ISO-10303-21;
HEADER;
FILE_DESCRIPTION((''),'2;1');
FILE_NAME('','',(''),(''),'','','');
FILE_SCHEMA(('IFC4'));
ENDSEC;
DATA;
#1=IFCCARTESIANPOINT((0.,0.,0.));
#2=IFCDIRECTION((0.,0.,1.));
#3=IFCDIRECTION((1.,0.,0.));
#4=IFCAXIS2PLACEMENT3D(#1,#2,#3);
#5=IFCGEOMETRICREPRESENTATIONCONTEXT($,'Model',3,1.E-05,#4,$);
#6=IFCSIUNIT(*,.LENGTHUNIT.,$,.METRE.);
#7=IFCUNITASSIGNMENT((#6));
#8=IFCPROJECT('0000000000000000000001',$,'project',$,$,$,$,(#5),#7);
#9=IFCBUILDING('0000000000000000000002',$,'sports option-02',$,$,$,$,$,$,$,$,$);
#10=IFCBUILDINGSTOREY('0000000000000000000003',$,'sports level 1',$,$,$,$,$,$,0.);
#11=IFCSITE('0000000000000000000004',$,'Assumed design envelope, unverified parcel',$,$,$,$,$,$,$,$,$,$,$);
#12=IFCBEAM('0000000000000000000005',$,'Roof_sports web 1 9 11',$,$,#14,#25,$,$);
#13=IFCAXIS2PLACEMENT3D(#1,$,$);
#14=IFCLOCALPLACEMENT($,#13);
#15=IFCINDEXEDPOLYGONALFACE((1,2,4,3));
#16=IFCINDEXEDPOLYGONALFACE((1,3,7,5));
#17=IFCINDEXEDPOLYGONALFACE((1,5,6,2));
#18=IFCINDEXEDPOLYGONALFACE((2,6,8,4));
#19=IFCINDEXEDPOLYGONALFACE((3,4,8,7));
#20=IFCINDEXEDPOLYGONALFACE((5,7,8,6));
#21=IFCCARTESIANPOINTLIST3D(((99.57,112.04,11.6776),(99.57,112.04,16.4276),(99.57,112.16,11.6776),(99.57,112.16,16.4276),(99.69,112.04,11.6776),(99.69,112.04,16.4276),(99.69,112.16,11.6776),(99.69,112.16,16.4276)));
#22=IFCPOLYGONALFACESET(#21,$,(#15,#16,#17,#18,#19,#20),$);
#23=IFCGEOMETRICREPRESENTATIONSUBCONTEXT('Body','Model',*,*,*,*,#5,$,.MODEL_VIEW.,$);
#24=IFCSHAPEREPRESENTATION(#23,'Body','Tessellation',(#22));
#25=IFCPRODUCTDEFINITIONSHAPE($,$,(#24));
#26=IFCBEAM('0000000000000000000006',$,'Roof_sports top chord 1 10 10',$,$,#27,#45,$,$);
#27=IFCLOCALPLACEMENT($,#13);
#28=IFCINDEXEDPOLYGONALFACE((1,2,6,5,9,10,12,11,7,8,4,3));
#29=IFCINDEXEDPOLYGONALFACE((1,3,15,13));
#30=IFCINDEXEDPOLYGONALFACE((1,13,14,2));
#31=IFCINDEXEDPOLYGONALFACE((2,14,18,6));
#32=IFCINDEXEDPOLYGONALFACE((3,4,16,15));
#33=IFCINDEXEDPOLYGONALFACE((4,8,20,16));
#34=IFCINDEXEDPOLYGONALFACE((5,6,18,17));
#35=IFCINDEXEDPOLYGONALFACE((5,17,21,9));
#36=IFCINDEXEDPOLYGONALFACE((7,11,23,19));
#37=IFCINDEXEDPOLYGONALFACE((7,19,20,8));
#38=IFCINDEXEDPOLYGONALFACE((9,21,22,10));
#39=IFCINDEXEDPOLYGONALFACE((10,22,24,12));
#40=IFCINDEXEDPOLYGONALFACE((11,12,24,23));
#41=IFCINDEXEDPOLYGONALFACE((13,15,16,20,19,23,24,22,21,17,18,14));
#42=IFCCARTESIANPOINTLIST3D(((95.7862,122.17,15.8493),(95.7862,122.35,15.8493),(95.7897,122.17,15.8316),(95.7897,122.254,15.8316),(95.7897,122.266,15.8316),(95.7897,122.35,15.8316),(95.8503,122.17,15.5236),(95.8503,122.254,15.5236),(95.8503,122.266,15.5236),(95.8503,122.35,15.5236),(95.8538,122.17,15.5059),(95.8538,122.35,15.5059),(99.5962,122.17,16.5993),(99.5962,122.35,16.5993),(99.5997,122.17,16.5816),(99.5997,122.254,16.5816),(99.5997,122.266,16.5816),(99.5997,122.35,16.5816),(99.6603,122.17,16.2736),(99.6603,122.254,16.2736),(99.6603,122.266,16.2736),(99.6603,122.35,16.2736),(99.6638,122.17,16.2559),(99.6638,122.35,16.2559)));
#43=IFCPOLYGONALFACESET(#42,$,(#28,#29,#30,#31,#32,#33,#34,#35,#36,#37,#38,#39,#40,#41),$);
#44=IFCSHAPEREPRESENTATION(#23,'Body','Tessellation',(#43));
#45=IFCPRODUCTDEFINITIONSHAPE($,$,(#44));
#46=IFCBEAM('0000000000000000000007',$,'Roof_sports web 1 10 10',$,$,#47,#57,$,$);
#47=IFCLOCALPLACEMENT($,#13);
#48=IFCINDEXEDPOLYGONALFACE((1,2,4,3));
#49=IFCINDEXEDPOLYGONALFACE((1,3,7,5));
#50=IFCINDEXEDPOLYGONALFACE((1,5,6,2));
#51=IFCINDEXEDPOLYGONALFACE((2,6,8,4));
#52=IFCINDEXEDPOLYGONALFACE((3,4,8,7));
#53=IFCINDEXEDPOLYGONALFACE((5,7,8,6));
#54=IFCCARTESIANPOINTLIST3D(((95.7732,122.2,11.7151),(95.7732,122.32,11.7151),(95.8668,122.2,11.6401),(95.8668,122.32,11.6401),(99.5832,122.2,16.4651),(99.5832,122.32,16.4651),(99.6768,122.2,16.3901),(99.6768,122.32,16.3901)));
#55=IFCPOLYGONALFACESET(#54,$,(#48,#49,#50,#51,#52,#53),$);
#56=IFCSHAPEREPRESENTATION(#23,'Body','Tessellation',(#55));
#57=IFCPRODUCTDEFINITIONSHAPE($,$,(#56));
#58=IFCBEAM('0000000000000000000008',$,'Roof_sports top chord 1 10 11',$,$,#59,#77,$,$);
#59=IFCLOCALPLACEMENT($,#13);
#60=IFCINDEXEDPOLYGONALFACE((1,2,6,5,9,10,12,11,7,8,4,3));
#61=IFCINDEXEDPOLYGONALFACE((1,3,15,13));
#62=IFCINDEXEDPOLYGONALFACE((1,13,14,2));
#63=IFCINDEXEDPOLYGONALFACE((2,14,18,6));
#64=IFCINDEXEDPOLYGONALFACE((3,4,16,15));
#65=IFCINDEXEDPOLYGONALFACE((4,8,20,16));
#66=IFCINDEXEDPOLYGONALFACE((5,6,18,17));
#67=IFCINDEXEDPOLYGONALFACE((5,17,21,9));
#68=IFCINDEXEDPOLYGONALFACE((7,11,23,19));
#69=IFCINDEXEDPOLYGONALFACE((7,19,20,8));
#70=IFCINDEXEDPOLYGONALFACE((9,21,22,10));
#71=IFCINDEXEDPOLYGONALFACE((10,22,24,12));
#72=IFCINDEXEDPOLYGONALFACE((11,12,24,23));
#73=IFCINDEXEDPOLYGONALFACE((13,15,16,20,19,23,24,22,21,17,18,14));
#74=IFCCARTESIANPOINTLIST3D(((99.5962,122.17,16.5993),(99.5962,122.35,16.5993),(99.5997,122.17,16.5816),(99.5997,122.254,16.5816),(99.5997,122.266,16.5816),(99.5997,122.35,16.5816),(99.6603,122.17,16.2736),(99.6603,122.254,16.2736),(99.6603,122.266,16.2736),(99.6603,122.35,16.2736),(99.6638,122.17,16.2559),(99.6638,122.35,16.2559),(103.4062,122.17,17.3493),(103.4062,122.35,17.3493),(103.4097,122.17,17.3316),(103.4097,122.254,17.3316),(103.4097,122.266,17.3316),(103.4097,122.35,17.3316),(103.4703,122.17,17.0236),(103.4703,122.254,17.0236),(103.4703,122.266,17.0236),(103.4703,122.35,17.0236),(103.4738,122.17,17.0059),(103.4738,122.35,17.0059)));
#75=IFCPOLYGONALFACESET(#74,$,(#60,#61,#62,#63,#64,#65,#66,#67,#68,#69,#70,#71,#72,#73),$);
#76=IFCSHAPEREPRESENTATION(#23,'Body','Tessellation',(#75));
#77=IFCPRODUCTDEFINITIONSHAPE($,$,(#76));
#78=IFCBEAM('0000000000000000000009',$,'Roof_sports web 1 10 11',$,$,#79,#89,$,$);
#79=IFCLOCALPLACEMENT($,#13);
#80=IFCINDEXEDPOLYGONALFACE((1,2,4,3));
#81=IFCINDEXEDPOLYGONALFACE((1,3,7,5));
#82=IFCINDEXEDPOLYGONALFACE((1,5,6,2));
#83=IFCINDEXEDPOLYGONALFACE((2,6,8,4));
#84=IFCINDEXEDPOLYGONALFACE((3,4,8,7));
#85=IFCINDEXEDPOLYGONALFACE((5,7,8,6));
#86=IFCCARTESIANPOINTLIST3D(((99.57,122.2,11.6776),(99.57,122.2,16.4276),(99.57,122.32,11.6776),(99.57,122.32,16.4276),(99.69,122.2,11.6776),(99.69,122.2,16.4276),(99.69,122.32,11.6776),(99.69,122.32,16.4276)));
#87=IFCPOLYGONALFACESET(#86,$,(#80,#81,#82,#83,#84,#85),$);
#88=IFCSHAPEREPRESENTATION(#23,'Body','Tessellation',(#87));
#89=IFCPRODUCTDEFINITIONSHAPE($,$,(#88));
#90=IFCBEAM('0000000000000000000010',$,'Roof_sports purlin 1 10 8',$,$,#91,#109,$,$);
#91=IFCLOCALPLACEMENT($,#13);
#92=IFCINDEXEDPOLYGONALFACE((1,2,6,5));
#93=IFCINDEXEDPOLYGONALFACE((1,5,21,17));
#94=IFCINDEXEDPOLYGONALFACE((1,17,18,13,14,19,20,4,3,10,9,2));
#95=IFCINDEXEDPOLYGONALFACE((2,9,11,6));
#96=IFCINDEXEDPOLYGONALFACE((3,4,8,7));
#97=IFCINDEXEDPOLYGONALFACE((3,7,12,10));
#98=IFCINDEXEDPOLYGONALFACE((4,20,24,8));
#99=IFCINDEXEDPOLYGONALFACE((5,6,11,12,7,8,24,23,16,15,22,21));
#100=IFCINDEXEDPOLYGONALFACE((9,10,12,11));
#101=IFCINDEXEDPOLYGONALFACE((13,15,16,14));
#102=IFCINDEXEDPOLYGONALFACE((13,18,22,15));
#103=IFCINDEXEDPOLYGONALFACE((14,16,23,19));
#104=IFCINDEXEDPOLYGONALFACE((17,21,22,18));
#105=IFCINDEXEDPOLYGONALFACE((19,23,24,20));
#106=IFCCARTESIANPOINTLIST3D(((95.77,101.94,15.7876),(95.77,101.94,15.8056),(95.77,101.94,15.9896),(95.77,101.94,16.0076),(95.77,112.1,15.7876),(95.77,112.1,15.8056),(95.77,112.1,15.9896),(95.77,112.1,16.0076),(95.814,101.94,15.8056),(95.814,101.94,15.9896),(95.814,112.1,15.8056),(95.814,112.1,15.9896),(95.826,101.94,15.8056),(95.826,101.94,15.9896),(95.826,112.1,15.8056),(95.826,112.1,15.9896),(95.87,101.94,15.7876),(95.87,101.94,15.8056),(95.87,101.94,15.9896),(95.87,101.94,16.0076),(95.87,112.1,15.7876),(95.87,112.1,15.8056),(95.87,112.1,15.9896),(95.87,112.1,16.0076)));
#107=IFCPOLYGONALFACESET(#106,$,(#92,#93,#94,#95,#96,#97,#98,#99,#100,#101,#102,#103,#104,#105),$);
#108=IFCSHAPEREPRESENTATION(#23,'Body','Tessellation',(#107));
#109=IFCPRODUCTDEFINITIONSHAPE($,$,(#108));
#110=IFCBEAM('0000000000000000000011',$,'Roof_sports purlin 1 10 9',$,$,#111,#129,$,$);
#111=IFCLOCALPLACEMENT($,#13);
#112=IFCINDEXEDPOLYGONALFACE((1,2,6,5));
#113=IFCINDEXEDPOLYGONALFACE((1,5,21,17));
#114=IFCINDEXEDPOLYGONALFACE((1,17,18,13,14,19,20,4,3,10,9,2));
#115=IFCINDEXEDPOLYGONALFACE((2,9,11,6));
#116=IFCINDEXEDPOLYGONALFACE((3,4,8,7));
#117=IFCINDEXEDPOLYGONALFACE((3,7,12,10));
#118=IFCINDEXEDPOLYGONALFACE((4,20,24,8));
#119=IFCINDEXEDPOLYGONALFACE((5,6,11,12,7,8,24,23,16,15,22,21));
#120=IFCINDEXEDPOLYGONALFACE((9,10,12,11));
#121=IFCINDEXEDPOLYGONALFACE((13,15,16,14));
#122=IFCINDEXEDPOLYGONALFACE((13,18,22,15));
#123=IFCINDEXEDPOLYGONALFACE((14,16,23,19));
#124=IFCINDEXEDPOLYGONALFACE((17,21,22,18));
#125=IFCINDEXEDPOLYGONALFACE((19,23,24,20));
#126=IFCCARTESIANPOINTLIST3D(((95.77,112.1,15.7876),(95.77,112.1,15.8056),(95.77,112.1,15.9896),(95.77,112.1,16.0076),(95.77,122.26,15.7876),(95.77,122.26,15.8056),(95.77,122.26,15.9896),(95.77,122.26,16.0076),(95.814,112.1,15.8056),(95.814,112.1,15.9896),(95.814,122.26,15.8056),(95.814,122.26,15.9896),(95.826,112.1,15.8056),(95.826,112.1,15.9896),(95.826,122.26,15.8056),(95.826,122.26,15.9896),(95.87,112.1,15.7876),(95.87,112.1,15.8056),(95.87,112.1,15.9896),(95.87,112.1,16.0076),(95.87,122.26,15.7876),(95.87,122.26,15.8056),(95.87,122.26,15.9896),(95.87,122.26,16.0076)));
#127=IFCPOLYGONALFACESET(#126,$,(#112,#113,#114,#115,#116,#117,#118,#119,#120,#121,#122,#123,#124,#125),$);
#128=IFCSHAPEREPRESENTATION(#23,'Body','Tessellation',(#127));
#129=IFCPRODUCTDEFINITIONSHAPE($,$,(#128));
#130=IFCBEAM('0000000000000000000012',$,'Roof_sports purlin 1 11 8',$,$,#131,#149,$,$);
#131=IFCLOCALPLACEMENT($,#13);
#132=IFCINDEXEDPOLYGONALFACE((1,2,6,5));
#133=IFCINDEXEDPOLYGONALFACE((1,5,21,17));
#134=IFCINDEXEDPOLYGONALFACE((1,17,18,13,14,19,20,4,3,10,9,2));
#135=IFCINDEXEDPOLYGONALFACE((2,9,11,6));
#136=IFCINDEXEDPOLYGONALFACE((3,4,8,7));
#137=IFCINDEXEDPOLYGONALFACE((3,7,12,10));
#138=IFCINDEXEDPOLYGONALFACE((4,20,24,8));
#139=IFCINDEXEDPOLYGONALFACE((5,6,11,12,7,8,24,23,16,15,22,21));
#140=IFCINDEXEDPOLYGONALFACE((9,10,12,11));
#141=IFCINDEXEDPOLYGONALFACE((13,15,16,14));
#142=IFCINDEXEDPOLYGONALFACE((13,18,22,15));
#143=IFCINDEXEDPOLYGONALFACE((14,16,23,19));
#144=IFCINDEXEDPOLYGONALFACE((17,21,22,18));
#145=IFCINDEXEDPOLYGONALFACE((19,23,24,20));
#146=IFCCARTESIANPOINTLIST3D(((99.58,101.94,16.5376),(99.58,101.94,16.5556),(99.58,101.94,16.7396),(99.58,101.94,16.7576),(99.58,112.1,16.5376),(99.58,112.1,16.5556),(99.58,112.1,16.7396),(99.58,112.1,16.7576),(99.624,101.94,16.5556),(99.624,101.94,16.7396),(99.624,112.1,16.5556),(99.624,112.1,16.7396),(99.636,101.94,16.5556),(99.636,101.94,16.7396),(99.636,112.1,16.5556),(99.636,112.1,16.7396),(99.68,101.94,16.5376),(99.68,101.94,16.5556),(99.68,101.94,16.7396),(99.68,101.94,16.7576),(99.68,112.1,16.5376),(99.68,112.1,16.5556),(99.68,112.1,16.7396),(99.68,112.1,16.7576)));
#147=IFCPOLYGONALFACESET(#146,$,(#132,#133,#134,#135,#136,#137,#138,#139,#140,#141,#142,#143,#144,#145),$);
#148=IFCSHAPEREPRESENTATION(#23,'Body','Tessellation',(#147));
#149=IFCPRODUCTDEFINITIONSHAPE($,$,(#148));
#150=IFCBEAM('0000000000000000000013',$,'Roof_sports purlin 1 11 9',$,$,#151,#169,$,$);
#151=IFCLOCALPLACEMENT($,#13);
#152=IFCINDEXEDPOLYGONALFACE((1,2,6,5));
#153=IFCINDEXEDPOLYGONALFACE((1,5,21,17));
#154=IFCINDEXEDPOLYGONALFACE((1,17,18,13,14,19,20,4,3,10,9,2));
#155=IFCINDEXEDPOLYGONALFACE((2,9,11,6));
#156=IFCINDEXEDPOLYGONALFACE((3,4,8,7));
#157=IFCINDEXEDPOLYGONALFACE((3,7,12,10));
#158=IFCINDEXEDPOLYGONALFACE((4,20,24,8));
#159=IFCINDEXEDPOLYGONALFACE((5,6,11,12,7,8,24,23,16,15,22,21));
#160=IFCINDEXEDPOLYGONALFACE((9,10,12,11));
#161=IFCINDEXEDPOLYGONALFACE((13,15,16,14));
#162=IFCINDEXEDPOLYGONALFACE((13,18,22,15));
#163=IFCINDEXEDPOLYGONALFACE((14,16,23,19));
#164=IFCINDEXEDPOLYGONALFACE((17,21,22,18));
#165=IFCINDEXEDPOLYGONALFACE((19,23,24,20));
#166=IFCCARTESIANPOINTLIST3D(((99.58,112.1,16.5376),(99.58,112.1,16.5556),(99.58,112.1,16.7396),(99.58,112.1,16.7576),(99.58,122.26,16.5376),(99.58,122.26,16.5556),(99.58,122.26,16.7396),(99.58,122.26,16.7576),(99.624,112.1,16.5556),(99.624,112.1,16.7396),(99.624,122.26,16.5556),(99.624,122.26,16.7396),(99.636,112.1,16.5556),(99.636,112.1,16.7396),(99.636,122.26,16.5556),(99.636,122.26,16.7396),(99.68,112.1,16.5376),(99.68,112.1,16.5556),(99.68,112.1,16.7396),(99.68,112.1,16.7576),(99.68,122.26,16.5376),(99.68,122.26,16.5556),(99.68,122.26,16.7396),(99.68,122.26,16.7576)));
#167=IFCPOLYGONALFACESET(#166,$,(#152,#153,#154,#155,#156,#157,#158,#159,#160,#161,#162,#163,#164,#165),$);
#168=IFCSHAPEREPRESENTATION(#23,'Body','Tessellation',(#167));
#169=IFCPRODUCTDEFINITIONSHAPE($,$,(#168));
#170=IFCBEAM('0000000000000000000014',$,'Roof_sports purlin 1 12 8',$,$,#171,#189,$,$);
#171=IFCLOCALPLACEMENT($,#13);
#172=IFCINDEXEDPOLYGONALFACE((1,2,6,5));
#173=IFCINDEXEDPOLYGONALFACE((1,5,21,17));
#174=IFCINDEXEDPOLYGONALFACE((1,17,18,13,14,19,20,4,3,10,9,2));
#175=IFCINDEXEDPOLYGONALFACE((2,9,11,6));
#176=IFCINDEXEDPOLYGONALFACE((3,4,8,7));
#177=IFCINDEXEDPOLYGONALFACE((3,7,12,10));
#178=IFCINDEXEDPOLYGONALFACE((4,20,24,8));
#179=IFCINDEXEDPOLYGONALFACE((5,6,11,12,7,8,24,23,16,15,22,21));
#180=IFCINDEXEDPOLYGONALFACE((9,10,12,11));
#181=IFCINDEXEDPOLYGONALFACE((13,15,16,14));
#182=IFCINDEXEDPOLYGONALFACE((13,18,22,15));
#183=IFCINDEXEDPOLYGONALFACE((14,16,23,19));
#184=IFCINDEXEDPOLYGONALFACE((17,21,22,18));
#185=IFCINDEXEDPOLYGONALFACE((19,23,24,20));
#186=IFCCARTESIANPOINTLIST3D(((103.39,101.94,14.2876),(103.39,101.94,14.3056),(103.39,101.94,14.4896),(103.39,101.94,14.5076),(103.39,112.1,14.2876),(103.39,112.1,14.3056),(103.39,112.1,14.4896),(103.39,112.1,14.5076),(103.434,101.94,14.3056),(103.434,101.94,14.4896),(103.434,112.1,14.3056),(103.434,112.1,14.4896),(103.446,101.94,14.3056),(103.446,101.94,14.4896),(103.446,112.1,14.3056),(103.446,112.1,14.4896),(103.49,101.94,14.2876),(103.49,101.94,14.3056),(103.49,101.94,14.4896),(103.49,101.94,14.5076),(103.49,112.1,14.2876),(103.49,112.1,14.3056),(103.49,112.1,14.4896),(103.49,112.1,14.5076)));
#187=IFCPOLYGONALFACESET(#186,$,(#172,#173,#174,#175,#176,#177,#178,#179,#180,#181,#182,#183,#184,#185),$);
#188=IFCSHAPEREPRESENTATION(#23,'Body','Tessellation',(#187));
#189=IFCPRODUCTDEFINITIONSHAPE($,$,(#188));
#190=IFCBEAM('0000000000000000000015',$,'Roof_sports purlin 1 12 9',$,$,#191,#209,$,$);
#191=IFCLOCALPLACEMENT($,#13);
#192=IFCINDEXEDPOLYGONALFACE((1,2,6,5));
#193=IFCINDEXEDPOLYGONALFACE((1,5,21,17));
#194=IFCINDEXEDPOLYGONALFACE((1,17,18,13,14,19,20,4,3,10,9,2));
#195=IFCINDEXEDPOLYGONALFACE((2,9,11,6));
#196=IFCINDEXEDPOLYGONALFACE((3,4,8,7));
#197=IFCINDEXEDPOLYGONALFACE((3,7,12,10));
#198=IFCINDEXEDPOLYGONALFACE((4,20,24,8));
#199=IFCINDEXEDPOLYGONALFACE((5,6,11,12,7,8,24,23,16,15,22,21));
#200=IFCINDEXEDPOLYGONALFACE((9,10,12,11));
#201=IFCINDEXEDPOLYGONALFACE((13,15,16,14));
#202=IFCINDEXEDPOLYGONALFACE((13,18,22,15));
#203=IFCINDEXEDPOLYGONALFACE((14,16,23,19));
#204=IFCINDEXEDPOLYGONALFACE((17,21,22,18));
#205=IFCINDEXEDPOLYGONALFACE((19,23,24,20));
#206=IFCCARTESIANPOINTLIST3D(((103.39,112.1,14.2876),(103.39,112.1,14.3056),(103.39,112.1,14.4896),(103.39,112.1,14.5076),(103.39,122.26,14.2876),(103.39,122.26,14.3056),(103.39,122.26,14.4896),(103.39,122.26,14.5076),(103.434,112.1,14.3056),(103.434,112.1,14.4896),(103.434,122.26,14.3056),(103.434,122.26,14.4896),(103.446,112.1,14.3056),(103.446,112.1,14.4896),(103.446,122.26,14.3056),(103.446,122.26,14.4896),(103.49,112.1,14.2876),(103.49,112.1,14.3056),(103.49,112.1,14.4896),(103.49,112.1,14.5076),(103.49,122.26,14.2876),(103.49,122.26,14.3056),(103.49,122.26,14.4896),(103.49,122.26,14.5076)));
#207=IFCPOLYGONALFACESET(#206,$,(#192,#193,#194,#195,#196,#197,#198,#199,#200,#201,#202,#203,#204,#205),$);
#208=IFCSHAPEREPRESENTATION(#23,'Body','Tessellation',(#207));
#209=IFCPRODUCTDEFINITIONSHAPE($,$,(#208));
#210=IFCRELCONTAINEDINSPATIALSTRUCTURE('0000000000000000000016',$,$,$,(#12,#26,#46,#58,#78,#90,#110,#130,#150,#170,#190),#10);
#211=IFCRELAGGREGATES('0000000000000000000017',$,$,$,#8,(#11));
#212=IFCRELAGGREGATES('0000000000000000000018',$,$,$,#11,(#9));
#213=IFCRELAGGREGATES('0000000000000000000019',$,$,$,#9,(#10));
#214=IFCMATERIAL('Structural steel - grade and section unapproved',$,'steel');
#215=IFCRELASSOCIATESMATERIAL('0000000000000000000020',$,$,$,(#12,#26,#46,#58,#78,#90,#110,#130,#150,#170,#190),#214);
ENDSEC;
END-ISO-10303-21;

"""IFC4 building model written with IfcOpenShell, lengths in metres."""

from ifc_helpers import new_model, si_unit, frame, origin_with_axes, place, context, subcontext, project, spatial, rectangle, i_section, extrude, material, element, save


model = new_model("IFC4")

# Units and contexts
model_context = context("Model", 3, precision=1e-05, world=origin_with_axes())
body_context = subcontext(model_context, "Body", "Model", "MODEL_VIEW")
ifc_project = project(units=[si_unit("LENGTHUNIT", "METRE")], contexts=[model_context])

# Site, building, storey
site = spatial("IfcSite", under=ifc_project, Name="Assumed design envelope, unverified parcel")
building = spatial("IfcBuilding", under=site, Name="sports option-02")
storey = spatial("IfcBuildingStorey", under=building, Name="sports level 1", Elevation=0.0)

# Shared definitions
ifc_material_1 = material(Name="Structural steel - grade and section unapproved", Category="steel")

# Beams
beam_1_placement = place(None, frame((99.63, 112.1, 11.6776), z_axis=(0.0, 0.0, 1.0), x_axis=(-1.0, 0.0, 0.0)))
element("IfcBeam", 1, at=beam_1_placement, inside=storey, material=ifc_material_1, Name="Roof_sports web 1 9 11", context=body_context, shape_type="SweptSolid", body=[
    extrude(rectangle(XDim=0.12, YDim=0.12), origin_with_axes(), (0.0, 0.0, 1.0), 4.75),
])
beam_2_placement = place(None, frame((95.82, 122.26, 15.6776), z_axis=(0.98117, 0.0, 0.193144), x_axis=(0.0, 1.0, 0.0)))
element("IfcBeam", 2, at=beam_2_placement, inside=storey, material=ifc_material_1, Name="Roof_sports top chord 1 10 10", context=body_context, shape_type="SweptSolid", body=[
    extrude(i_section(OverallWidth=0.18, OverallDepth=0.35, WebThickness=0.012, FlangeThickness=0.018, FilletRadius=0.0), origin_with_axes(), (0.0, 0.0, 1.0), 3.8831),
])
beam_3_placement = place(None, frame((95.82, 122.26, 11.6776), z_axis=(0.625696, 0.0, 0.780067), x_axis=(0.0, 1.0, 0.0)))
element("IfcBeam", 3, at=beam_3_placement, inside=storey, material=ifc_material_1, Name="Roof_sports web 1 10 10", context=body_context, shape_type="SweptSolid", body=[
    extrude(rectangle(XDim=0.12, YDim=0.12), origin_with_axes(), (0.0, 0.0, 1.0), 6.0892),
])
beam_4_placement = place(None, frame((99.63, 122.26, 16.4276), z_axis=(0.981171, 0.0, 0.193143), x_axis=(0.0, 1.0, 0.0)))
element("IfcBeam", 4, at=beam_4_placement, inside=storey, material=ifc_material_1, Name="Roof_sports top chord 1 10 11", context=body_context, shape_type="SweptSolid", body=[
    extrude(i_section(OverallWidth=0.18, OverallDepth=0.35, WebThickness=0.012, FlangeThickness=0.018, FilletRadius=0.0), origin_with_axes(), (0.0, 0.0, 1.0), 3.8831),
])
beam_5_placement = place(None, frame((99.63, 122.26, 11.6776), z_axis=(0.0, 0.0, 1.0), x_axis=(-1.0, 0.0, 0.0)))
element("IfcBeam", 5, at=beam_5_placement, inside=storey, material=ifc_material_1, Name="Roof_sports web 1 10 11", context=body_context, shape_type="SweptSolid", body=[
    extrude(rectangle(XDim=0.12, YDim=0.12), origin_with_axes(), (0.0, 0.0, 1.0), 4.75),
])
beam_6_placement = place(None, frame((95.82, 101.94, 15.8976), z_axis=(0.0, 1.0, 0.0), x_axis=(-1.0, 0.0, 0.0)))
element("IfcBeam", 6, at=beam_6_placement, inside=storey, material=ifc_material_1, Name="Roof_sports purlin 1 10 8", context=body_context, shape_type="SweptSolid", body=[
    extrude(i_section(OverallWidth=0.1, OverallDepth=0.22, WebThickness=0.012, FlangeThickness=0.018, FilletRadius=0.0), origin_with_axes(), (0.0, 0.0, 1.0), 10.16),
])
beam_7_placement = place(None, frame((95.82, 112.1, 15.8976), z_axis=(0.0, 1.0, 0.0), x_axis=(-1.0, 0.0, 0.0)))
element("IfcBeam", 7, at=beam_7_placement, inside=storey, material=ifc_material_1, Name="Roof_sports purlin 1 10 9", context=body_context, shape_type="SweptSolid", body=[
    extrude(i_section(OverallWidth=0.1, OverallDepth=0.22, WebThickness=0.012, FlangeThickness=0.018, FilletRadius=0.0), origin_with_axes(), (0.0, 0.0, 1.0), 10.16),
])
beam_8_placement = place(None, frame((99.63, 101.94, 16.6476), z_axis=(0.0, 1.0, 0.0), x_axis=(-1.0, 0.0, 0.0)))
element("IfcBeam", 8, at=beam_8_placement, inside=storey, material=ifc_material_1, Name="Roof_sports purlin 1 11 8", context=body_context, shape_type="SweptSolid", body=[
    extrude(i_section(OverallWidth=0.1, OverallDepth=0.22, WebThickness=0.012, FlangeThickness=0.018, FilletRadius=0.0), origin_with_axes(), (0.0, 0.0, 1.0), 10.16),
])
beam_9_placement = place(None, frame((99.63, 112.1, 16.6476), z_axis=(0.0, 1.0, 0.0), x_axis=(-1.0, 0.0, 0.0)))
element("IfcBeam", 9, at=beam_9_placement, inside=storey, material=ifc_material_1, Name="Roof_sports purlin 1 11 9", context=body_context, shape_type="SweptSolid", body=[
    extrude(i_section(OverallWidth=0.1, OverallDepth=0.22, WebThickness=0.012, FlangeThickness=0.018, FilletRadius=0.0), origin_with_axes(), (0.0, 0.0, 1.0), 10.16),
])
beam_10_placement = place(None, frame((103.44, 101.94, 14.3976), z_axis=(0.0, 1.0, 0.0), x_axis=(-1.0, 0.0, 0.0)))
element("IfcBeam", 10, at=beam_10_placement, inside=storey, material=ifc_material_1, Name="Roof_sports purlin 1 12 8", context=body_context, shape_type="SweptSolid", body=[
    extrude(i_section(OverallWidth=0.1, OverallDepth=0.22, WebThickness=0.012, FlangeThickness=0.018, FilletRadius=0.0), origin_with_axes(), (0.0, 0.0, 1.0), 10.16),
])
beam_11_placement = place(None, frame((103.44, 112.1, 14.3976), z_axis=(0.0, 1.0, 0.0), x_axis=(-1.0, 0.0, 0.0)))
element("IfcBeam", 11, at=beam_11_placement, inside=storey, material=ifc_material_1, Name="Roof_sports purlin 1 12 9", context=body_context, shape_type="SweptSolid", body=[
    extrude(i_section(OverallWidth=0.1, OverallDepth=0.22, WebThickness=0.012, FlangeThickness=0.018, FilletRadius=0.0), origin_with_axes(), (0.0, 0.0, 1.0), 10.16),
])

save(model, "model.ifc")
